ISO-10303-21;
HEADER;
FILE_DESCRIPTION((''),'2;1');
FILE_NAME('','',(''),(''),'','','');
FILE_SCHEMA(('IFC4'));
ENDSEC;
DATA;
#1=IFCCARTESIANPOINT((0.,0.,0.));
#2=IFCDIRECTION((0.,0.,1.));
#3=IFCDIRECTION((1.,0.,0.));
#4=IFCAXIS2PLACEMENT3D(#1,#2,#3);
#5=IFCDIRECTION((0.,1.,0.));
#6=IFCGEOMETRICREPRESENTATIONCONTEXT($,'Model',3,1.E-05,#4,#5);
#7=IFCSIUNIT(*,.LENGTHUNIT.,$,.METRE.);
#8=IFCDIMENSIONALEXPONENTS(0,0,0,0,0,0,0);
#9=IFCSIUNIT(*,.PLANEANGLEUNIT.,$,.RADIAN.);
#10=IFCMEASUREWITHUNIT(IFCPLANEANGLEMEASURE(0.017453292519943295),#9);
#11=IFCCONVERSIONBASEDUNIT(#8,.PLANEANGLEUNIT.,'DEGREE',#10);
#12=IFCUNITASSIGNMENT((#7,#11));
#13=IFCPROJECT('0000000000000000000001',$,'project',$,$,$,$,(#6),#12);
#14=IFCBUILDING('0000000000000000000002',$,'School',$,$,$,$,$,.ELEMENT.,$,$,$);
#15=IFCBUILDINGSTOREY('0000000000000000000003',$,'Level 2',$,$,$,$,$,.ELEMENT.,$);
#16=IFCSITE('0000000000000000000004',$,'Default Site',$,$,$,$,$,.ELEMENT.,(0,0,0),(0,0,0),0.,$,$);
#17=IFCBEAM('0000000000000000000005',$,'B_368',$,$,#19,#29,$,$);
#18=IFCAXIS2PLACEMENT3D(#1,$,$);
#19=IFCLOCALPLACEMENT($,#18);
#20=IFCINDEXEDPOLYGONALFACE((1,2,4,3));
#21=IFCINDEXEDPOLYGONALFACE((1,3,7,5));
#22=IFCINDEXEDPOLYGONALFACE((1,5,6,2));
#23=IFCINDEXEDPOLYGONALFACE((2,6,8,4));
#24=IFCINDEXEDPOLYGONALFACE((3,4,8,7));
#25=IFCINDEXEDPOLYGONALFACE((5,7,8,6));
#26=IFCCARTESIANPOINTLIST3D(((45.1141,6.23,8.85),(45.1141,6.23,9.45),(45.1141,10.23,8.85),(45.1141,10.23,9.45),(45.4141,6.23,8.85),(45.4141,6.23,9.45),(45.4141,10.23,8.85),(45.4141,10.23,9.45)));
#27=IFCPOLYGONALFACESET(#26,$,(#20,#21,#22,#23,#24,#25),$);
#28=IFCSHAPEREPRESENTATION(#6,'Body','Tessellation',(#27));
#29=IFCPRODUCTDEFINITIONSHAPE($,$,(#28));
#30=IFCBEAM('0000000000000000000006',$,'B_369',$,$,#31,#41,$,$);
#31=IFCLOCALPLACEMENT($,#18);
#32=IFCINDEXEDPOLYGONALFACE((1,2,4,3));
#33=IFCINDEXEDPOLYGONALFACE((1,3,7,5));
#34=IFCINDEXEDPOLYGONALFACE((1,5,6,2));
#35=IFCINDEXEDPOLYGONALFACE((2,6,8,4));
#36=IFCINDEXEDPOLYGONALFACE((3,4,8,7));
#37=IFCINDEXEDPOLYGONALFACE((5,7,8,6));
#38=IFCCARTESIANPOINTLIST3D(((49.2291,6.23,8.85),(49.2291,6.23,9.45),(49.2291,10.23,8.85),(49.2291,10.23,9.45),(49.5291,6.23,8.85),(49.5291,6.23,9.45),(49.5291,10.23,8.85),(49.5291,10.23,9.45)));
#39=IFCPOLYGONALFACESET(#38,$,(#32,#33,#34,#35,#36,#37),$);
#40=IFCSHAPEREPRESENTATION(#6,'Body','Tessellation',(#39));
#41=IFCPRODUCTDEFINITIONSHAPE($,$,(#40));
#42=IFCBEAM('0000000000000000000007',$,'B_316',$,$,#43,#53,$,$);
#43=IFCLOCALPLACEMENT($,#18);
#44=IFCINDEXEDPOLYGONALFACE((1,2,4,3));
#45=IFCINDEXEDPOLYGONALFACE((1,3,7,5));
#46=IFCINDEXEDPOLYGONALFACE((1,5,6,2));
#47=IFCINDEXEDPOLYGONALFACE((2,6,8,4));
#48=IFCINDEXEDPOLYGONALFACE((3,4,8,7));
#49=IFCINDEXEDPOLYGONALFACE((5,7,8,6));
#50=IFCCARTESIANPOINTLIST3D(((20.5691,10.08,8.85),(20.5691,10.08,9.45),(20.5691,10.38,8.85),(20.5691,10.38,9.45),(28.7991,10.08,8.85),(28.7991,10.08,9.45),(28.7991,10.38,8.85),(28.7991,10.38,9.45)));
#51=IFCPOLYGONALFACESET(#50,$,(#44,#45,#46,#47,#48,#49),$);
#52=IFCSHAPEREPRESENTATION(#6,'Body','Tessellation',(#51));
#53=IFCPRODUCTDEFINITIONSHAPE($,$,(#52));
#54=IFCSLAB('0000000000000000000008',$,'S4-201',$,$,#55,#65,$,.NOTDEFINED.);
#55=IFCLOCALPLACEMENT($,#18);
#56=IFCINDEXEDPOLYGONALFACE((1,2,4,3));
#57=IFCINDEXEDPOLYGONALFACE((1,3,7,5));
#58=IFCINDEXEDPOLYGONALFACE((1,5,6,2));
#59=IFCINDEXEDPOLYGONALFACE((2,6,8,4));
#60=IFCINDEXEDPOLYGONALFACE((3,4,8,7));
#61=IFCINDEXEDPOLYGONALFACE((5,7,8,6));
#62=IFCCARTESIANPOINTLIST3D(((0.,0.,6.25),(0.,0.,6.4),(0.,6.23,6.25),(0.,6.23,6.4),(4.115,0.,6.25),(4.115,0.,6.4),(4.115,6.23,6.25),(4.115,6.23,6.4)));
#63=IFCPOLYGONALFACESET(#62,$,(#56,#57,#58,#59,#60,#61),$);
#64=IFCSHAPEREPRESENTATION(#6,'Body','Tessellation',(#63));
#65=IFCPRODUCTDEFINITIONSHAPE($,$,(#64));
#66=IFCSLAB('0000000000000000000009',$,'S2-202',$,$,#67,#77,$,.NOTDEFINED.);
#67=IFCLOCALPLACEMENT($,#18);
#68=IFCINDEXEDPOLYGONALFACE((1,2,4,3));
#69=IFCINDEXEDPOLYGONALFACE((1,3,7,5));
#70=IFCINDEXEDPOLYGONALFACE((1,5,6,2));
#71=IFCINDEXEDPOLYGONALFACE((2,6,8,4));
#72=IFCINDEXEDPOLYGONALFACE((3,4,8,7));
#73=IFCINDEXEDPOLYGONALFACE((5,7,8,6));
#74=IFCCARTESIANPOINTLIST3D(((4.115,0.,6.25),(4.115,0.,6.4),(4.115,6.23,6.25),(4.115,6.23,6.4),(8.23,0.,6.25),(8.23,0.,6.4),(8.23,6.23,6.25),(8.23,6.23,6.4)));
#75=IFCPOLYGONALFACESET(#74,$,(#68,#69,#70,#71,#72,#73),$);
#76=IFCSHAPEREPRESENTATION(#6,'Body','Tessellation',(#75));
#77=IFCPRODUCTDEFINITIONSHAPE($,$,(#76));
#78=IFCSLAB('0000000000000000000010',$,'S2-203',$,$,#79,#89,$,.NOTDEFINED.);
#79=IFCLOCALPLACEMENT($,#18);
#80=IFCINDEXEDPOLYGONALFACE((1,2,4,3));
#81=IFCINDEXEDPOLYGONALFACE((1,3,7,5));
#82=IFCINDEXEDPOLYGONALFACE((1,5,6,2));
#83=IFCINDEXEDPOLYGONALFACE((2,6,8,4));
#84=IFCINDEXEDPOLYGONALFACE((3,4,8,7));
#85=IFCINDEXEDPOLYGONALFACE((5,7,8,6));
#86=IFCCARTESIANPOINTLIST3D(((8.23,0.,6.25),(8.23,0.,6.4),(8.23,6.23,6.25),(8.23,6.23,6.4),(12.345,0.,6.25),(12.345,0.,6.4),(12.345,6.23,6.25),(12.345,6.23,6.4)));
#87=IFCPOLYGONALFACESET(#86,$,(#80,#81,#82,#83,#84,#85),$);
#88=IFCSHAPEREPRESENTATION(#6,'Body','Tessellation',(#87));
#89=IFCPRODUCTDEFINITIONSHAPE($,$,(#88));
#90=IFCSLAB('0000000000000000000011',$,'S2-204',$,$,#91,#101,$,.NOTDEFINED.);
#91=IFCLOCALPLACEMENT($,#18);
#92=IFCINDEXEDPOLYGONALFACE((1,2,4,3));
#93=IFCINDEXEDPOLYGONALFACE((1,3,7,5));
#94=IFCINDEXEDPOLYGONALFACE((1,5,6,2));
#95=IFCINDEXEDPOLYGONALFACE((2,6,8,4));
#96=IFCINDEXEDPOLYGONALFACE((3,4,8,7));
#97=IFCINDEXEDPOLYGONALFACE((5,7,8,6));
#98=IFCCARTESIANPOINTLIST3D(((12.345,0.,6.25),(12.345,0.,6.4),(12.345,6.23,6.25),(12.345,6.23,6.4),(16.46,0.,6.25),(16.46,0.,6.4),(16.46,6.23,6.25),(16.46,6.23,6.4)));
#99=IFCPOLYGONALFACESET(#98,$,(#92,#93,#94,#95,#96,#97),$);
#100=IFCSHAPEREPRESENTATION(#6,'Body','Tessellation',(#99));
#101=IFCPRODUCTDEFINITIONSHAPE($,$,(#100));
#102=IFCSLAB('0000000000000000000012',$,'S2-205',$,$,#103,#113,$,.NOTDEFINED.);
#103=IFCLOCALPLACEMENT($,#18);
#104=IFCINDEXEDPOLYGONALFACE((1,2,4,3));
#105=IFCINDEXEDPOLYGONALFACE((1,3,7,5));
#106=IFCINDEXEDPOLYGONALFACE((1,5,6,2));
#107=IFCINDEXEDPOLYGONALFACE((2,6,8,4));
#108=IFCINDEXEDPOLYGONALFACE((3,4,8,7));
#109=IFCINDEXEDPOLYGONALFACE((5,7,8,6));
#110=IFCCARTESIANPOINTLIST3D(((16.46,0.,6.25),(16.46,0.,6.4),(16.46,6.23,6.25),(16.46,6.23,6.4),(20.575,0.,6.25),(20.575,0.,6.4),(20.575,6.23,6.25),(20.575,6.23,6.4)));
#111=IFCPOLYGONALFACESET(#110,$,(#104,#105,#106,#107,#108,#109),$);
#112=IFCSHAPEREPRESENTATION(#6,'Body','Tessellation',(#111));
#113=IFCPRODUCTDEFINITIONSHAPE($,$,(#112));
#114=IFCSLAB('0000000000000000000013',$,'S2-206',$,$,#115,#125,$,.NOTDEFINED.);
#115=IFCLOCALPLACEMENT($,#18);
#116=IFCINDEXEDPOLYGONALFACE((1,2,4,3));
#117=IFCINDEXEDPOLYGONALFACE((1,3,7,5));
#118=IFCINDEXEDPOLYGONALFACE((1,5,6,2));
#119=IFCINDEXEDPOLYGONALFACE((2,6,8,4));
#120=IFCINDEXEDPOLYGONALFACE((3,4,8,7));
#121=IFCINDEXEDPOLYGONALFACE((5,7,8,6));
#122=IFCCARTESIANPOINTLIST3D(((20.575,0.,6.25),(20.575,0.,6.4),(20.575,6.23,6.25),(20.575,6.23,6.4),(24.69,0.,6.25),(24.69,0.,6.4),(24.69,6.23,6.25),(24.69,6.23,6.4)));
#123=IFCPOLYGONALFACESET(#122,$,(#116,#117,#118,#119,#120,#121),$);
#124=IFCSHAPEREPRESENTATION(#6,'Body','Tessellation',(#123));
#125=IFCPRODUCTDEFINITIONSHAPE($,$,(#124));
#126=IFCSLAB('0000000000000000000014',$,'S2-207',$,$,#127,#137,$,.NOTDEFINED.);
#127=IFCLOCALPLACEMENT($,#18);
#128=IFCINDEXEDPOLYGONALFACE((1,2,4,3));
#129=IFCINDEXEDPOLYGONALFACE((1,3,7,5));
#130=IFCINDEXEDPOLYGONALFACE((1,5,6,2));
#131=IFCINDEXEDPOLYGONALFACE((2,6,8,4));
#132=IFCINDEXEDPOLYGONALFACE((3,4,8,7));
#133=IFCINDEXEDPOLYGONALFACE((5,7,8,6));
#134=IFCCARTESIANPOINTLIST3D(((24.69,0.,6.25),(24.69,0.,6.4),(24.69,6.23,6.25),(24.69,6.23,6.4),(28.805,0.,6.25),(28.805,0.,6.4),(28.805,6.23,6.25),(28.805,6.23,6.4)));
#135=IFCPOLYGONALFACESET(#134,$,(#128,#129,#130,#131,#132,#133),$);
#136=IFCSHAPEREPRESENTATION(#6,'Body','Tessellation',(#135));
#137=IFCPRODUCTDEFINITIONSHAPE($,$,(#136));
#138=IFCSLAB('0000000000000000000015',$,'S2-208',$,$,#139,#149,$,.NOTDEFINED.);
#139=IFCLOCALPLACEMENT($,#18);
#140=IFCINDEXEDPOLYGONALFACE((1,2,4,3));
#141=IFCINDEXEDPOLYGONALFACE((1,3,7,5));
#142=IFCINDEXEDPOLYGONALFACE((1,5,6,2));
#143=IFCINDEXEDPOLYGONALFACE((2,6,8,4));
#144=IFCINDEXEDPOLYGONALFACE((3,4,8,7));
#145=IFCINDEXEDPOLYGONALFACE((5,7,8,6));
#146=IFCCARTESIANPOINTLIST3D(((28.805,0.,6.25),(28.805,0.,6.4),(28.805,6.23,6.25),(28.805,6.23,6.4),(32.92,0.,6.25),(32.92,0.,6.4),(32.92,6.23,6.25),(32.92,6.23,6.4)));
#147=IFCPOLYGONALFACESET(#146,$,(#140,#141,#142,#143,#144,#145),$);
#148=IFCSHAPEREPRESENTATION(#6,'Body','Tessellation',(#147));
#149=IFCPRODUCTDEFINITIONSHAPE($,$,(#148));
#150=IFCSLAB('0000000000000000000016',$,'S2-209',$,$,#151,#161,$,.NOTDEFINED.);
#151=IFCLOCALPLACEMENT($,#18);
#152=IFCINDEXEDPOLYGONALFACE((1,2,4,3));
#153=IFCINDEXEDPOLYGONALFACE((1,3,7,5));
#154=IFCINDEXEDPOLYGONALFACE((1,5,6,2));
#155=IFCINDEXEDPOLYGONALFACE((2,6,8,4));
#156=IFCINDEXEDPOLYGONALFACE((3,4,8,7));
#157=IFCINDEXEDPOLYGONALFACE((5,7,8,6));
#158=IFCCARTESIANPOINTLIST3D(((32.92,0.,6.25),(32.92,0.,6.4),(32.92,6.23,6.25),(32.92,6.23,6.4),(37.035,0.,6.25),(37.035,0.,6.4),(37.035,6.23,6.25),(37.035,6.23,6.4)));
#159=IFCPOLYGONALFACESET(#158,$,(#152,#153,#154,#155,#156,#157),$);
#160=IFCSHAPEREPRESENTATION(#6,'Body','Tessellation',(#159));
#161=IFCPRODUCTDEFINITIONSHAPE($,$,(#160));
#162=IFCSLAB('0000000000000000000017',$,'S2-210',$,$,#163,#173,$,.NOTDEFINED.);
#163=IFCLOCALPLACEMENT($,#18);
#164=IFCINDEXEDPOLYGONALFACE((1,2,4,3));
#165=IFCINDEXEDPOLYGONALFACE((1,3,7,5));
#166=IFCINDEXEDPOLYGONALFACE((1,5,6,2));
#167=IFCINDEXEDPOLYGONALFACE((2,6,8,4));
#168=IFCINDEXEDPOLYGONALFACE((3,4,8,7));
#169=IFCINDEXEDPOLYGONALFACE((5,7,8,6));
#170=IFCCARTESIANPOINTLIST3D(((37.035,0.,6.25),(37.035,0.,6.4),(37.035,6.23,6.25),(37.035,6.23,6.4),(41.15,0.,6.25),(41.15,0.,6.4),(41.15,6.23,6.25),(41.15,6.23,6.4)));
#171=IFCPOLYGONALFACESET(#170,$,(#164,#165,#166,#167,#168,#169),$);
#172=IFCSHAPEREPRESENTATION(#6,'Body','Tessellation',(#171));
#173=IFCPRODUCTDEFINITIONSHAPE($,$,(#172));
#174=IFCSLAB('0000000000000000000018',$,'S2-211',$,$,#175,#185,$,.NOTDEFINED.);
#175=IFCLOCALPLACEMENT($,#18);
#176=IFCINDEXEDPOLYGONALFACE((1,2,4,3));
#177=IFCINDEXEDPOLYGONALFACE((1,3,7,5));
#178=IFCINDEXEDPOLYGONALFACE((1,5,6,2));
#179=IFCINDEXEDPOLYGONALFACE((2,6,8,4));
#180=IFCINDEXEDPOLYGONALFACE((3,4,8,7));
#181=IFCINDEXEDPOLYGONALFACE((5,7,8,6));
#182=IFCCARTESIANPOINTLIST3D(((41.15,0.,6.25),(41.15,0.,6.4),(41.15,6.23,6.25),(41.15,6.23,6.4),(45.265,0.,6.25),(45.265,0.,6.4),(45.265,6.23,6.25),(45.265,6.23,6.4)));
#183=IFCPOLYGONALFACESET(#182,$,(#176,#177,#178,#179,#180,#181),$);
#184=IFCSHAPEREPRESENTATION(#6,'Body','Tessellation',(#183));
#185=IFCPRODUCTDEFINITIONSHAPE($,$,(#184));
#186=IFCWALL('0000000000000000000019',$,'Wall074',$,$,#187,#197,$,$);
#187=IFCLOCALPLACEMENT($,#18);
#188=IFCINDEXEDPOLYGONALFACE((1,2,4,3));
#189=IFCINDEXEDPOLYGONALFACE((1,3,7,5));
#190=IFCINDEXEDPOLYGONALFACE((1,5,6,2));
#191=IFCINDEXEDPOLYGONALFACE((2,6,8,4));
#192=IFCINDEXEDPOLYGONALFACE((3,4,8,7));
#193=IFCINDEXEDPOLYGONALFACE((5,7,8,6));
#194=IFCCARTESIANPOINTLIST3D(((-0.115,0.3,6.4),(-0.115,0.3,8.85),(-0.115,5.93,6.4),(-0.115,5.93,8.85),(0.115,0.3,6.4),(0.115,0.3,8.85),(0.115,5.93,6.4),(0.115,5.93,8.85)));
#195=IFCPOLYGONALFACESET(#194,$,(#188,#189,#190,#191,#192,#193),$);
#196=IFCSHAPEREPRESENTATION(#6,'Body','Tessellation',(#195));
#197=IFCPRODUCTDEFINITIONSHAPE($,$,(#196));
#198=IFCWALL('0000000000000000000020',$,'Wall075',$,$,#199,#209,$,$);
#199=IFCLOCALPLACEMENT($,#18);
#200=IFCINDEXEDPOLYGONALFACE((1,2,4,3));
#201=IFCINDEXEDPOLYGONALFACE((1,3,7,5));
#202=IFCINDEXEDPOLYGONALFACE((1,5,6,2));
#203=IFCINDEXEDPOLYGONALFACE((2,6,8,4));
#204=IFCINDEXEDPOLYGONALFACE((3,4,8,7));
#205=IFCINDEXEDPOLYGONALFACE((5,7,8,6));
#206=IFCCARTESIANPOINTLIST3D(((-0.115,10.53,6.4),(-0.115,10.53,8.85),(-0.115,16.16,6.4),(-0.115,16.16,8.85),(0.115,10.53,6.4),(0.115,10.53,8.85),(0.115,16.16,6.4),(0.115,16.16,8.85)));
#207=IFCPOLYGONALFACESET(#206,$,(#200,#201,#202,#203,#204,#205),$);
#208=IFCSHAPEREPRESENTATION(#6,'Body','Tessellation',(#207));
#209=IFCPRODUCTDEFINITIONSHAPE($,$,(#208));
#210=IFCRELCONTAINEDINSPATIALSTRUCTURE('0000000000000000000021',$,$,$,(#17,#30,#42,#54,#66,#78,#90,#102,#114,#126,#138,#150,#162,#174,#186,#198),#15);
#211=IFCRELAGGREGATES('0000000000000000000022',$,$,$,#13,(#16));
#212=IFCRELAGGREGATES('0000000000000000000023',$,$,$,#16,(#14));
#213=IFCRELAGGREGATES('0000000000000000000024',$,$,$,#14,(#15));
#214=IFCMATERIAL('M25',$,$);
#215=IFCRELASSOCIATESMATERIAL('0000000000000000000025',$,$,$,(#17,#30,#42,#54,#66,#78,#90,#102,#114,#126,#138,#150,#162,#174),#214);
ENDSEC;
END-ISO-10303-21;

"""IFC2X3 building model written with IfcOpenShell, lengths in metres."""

from ifc_helpers import new_model, entity, si_unit, converted_unit, direction, frame, frame_2d, origin_with_axes, place, context, project, spatial, rectangle, extrude, material, element, save


model = new_model("IFC2X3")

# Units and contexts
model_context = context("Model", 3, precision=1e-05, world=origin_with_axes(), true_north=direction((0.0, 1.0, 0.0)))
ifc_project = project(units=[si_unit("LENGTHUNIT", "METRE"), converted_unit("PLANEANGLEUNIT", "DEGREE", entity("IfcPlaneAngleMeasure", 0.017453292519943295), si_unit("PLANEANGLEUNIT", "RADIAN"), dimensions=[0, 0, 0, 0, 0, 0, 0])], contexts=[model_context])

# Site, building, storey
site = spatial("IfcSite", under=ifc_project, Name="Default Site", CompositionType="ELEMENT", RefLatitude=(0, 0, 0), RefLongitude=(0, 0, 0), RefElevation=0.0)
building = spatial("IfcBuilding", under=site, Name="School", CompositionType="ELEMENT")
storey = spatial("IfcBuildingStorey", under=building, Name="Level 2", CompositionType="ELEMENT")

# Beams
ifc_material = material(Name="M25")
placement = place(None, origin_with_axes())
element("IfcBeam", 1, at=placement, inside=storey, material=ifc_material, Name="B_368", context=model_context, shape_type="SweptSolid", body=[
    extrude(rectangle(XDim=0.3, YDim=0.6, at=frame_2d((0.0, 0.0), x_axis=(0.0, 1.0, 0.0))), frame((45.2641, 6.23, 9.15), z_axis=(0.0, 1.0, 0.0), x_axis=(0.0, 0.0, -1.0)), (0.0, 0.0, 1.0), 4.0),
])
element("IfcBeam", 2, at=placement, inside=storey, material=ifc_material, Name="B_369", context=model_context, shape_type="SweptSolid", body=[
    extrude(rectangle(XDim=0.3, YDim=0.6, at=frame_2d((0.0, 0.0), x_axis=(0.0, 1.0, 0.0))), frame((49.3791, 6.23, 9.15), z_axis=(0.0, 1.0, 0.0), x_axis=(0.0, 0.0, -1.0)), (0.0, 0.0, 1.0), 4.0),
])
element("IfcBeam", 3, at=placement, inside=storey, material=ifc_material, Name="B_316", context=model_context, shape_type="SweptSolid", body=[
    extrude(rectangle(XDim=0.3, YDim=0.6, at=frame_2d((0.0, 0.0), x_axis=(0.0, 1.0, 0.0))), frame((20.5691, 10.23, 9.15), z_axis=(1.0, 0.0, 0.0), x_axis=(0.0, 0.0, -1.0)), (0.0, 0.0, 1.0), 8.23),
])

# Slabs
element("IfcSlab", 4, at=placement, inside=storey, material=ifc_material, Name="S4-201", PredefinedType="NOTDEFINED", context=model_context, shape_type="SweptSolid", body=[
    extrude(rectangle(XDim=4.115, YDim=6.23, at=frame_2d((0.0, 0.0), x_axis=(1.0, 0.0, 0.0))), frame((2.0575, 3.115, 6.25), z_axis=(0.0, 0.0, 1.0), x_axis=(1.0, 0.0, 0.0)), (0.0, 0.0, 1.0), 0.15),
])
element("IfcSlab", 5, at=placement, inside=storey, material=ifc_material, Name="S2-202", PredefinedType="NOTDEFINED", context=model_context, shape_type="SweptSolid", body=[
    extrude(rectangle(XDim=4.115, YDim=6.23, at=frame_2d((0.0, 0.0), x_axis=(1.0, 0.0, 0.0))), frame((6.1725, 3.115, 6.25), z_axis=(0.0, 0.0, 1.0), x_axis=(1.0, 0.0, 0.0)), (0.0, 0.0, 1.0), 0.15),
])
element("IfcSlab", 6, at=placement, inside=storey, material=ifc_material, Name="S2-203", PredefinedType="NOTDEFINED", context=model_context, shape_type="SweptSolid", body=[
    extrude(rectangle(XDim=4.115, YDim=6.23, at=frame_2d((0.0, 0.0), x_axis=(1.0, 0.0, 0.0))), frame((10.2875, 3.115, 6.25), z_axis=(0.0, 0.0, 1.0), x_axis=(1.0, 0.0, 0.0)), (0.0, 0.0, 1.0), 0.15),
])
element("IfcSlab", 7, at=placement, inside=storey, material=ifc_material, Name="S2-204", PredefinedType="NOTDEFINED", context=model_context, shape_type="SweptSolid", body=[
    extrude(rectangle(XDim=4.115, YDim=6.23, at=frame_2d((0.0, 0.0), x_axis=(1.0, 0.0, 0.0))), frame((14.4025, 3.115, 6.25), z_axis=(0.0, 0.0, 1.0), x_axis=(1.0, 0.0, 0.0)), (0.0, 0.0, 1.0), 0.15),
])
element("IfcSlab", 8, at=placement, inside=storey, material=ifc_material, Name="S2-205", PredefinedType="NOTDEFINED", context=model_context, shape_type="SweptSolid", body=[
    extrude(rectangle(XDim=4.115, YDim=6.23, at=frame_2d((0.0, 0.0), x_axis=(1.0, 0.0, 0.0))), frame((18.5175, 3.115, 6.25), z_axis=(0.0, 0.0, 1.0), x_axis=(1.0, 0.0, 0.0)), (0.0, 0.0, 1.0), 0.15),
])
element("IfcSlab", 9, at=placement, inside=storey, material=ifc_material, Name="S2-206", PredefinedType="NOTDEFINED", context=model_context, shape_type="SweptSolid", body=[
    extrude(rectangle(XDim=4.115, YDim=6.23, at=frame_2d((0.0, 0.0), x_axis=(1.0, 0.0, 0.0))), frame((22.6325, 3.115, 6.25), z_axis=(0.0, 0.0, 1.0), x_axis=(1.0, 0.0, 0.0)), (0.0, 0.0, 1.0), 0.15),
])
element("IfcSlab", 10, at=placement, inside=storey, material=ifc_material, Name="S2-207", PredefinedType="NOTDEFINED", context=model_context, shape_type="SweptSolid", body=[
    extrude(rectangle(XDim=4.115, YDim=6.23, at=frame_2d((0.0, 0.0), x_axis=(1.0, 0.0, 0.0))), frame((26.7475, 3.115, 6.25), z_axis=(0.0, 0.0, 1.0), x_axis=(1.0, 0.0, 0.0)), (0.0, 0.0, 1.0), 0.15),
])
element("IfcSlab", 11, at=placement, inside=storey, material=ifc_material, Name="S2-208", PredefinedType="NOTDEFINED", context=model_context, shape_type="SweptSolid", body=[
    extrude(rectangle(XDim=4.115, YDim=6.23, at=frame_2d((0.0, 0.0), x_axis=(1.0, 0.0, 0.0))), frame((30.8625, 3.115, 6.25), z_axis=(0.0, 0.0, 1.0), x_axis=(1.0, 0.0, 0.0)), (0.0, 0.0, 1.0), 0.15),
])
element("IfcSlab", 12, at=placement, inside=storey, material=ifc_material, Name="S2-209", PredefinedType="NOTDEFINED", context=model_context, shape_type="SweptSolid", body=[
    extrude(rectangle(XDim=4.115, YDim=6.23, at=frame_2d((0.0, 0.0), x_axis=(1.0, 0.0, 0.0))), frame((34.9775, 3.115, 6.25), z_axis=(0.0, 0.0, 1.0), x_axis=(1.0, 0.0, 0.0)), (0.0, 0.0, 1.0), 0.15),
])
element("IfcSlab", 13, at=placement, inside=storey, material=ifc_material, Name="S2-210", PredefinedType="NOTDEFINED", context=model_context, shape_type="SweptSolid", body=[
    extrude(rectangle(XDim=4.115, YDim=6.23, at=frame_2d((0.0, 0.0), x_axis=(1.0, 0.0, 0.0))), frame((39.0925, 3.115, 6.25), z_axis=(0.0, 0.0, 1.0), x_axis=(1.0, 0.0, 0.0)), (0.0, 0.0, 1.0), 0.15),
])
element("IfcSlab", 14, at=placement, inside=storey, material=ifc_material, Name="S2-211", PredefinedType="NOTDEFINED", context=model_context, shape_type="SweptSolid", body=[
    extrude(rectangle(XDim=4.115, YDim=6.23, at=frame_2d((0.0, 0.0), x_axis=(1.0, 0.0, 0.0))), frame((43.2075, 3.115, 6.25), z_axis=(0.0, 0.0, 1.0), x_axis=(1.0, 0.0, 0.0)), (0.0, 0.0, 1.0), 0.15),
])

# Walls
element("IfcWall", 15, at=placement, inside=storey, Name="Wall074", context=model_context, shape_type="SweptSolid", body=[
    extrude(rectangle(XDim=5.63, YDim=0.23, at=frame_2d((0.0, 0.0), x_axis=(0.0, 1.0, 0.0))), frame((0.0, 3.115, 6.4), z_axis=(0.0, 0.0, 1.0), x_axis=(1.0, 0.0, 0.0)), (0.0, 0.0, 1.0), 2.45),
])
element("IfcWall", 16, at=placement, inside=storey, Name="Wall075", context=model_context, shape_type="SweptSolid", body=[
    extrude(rectangle(XDim=5.63, YDim=0.23, at=frame_2d((0.0, 0.0), x_axis=(0.0, 1.0, 0.0))), frame((0.0, 13.345, 6.4), z_axis=(0.0, 0.0, 1.0), x_axis=(1.0, 0.0, 0.0)), (0.0, 0.0, 1.0), 2.45),
])

save(model, "model.ifc")
